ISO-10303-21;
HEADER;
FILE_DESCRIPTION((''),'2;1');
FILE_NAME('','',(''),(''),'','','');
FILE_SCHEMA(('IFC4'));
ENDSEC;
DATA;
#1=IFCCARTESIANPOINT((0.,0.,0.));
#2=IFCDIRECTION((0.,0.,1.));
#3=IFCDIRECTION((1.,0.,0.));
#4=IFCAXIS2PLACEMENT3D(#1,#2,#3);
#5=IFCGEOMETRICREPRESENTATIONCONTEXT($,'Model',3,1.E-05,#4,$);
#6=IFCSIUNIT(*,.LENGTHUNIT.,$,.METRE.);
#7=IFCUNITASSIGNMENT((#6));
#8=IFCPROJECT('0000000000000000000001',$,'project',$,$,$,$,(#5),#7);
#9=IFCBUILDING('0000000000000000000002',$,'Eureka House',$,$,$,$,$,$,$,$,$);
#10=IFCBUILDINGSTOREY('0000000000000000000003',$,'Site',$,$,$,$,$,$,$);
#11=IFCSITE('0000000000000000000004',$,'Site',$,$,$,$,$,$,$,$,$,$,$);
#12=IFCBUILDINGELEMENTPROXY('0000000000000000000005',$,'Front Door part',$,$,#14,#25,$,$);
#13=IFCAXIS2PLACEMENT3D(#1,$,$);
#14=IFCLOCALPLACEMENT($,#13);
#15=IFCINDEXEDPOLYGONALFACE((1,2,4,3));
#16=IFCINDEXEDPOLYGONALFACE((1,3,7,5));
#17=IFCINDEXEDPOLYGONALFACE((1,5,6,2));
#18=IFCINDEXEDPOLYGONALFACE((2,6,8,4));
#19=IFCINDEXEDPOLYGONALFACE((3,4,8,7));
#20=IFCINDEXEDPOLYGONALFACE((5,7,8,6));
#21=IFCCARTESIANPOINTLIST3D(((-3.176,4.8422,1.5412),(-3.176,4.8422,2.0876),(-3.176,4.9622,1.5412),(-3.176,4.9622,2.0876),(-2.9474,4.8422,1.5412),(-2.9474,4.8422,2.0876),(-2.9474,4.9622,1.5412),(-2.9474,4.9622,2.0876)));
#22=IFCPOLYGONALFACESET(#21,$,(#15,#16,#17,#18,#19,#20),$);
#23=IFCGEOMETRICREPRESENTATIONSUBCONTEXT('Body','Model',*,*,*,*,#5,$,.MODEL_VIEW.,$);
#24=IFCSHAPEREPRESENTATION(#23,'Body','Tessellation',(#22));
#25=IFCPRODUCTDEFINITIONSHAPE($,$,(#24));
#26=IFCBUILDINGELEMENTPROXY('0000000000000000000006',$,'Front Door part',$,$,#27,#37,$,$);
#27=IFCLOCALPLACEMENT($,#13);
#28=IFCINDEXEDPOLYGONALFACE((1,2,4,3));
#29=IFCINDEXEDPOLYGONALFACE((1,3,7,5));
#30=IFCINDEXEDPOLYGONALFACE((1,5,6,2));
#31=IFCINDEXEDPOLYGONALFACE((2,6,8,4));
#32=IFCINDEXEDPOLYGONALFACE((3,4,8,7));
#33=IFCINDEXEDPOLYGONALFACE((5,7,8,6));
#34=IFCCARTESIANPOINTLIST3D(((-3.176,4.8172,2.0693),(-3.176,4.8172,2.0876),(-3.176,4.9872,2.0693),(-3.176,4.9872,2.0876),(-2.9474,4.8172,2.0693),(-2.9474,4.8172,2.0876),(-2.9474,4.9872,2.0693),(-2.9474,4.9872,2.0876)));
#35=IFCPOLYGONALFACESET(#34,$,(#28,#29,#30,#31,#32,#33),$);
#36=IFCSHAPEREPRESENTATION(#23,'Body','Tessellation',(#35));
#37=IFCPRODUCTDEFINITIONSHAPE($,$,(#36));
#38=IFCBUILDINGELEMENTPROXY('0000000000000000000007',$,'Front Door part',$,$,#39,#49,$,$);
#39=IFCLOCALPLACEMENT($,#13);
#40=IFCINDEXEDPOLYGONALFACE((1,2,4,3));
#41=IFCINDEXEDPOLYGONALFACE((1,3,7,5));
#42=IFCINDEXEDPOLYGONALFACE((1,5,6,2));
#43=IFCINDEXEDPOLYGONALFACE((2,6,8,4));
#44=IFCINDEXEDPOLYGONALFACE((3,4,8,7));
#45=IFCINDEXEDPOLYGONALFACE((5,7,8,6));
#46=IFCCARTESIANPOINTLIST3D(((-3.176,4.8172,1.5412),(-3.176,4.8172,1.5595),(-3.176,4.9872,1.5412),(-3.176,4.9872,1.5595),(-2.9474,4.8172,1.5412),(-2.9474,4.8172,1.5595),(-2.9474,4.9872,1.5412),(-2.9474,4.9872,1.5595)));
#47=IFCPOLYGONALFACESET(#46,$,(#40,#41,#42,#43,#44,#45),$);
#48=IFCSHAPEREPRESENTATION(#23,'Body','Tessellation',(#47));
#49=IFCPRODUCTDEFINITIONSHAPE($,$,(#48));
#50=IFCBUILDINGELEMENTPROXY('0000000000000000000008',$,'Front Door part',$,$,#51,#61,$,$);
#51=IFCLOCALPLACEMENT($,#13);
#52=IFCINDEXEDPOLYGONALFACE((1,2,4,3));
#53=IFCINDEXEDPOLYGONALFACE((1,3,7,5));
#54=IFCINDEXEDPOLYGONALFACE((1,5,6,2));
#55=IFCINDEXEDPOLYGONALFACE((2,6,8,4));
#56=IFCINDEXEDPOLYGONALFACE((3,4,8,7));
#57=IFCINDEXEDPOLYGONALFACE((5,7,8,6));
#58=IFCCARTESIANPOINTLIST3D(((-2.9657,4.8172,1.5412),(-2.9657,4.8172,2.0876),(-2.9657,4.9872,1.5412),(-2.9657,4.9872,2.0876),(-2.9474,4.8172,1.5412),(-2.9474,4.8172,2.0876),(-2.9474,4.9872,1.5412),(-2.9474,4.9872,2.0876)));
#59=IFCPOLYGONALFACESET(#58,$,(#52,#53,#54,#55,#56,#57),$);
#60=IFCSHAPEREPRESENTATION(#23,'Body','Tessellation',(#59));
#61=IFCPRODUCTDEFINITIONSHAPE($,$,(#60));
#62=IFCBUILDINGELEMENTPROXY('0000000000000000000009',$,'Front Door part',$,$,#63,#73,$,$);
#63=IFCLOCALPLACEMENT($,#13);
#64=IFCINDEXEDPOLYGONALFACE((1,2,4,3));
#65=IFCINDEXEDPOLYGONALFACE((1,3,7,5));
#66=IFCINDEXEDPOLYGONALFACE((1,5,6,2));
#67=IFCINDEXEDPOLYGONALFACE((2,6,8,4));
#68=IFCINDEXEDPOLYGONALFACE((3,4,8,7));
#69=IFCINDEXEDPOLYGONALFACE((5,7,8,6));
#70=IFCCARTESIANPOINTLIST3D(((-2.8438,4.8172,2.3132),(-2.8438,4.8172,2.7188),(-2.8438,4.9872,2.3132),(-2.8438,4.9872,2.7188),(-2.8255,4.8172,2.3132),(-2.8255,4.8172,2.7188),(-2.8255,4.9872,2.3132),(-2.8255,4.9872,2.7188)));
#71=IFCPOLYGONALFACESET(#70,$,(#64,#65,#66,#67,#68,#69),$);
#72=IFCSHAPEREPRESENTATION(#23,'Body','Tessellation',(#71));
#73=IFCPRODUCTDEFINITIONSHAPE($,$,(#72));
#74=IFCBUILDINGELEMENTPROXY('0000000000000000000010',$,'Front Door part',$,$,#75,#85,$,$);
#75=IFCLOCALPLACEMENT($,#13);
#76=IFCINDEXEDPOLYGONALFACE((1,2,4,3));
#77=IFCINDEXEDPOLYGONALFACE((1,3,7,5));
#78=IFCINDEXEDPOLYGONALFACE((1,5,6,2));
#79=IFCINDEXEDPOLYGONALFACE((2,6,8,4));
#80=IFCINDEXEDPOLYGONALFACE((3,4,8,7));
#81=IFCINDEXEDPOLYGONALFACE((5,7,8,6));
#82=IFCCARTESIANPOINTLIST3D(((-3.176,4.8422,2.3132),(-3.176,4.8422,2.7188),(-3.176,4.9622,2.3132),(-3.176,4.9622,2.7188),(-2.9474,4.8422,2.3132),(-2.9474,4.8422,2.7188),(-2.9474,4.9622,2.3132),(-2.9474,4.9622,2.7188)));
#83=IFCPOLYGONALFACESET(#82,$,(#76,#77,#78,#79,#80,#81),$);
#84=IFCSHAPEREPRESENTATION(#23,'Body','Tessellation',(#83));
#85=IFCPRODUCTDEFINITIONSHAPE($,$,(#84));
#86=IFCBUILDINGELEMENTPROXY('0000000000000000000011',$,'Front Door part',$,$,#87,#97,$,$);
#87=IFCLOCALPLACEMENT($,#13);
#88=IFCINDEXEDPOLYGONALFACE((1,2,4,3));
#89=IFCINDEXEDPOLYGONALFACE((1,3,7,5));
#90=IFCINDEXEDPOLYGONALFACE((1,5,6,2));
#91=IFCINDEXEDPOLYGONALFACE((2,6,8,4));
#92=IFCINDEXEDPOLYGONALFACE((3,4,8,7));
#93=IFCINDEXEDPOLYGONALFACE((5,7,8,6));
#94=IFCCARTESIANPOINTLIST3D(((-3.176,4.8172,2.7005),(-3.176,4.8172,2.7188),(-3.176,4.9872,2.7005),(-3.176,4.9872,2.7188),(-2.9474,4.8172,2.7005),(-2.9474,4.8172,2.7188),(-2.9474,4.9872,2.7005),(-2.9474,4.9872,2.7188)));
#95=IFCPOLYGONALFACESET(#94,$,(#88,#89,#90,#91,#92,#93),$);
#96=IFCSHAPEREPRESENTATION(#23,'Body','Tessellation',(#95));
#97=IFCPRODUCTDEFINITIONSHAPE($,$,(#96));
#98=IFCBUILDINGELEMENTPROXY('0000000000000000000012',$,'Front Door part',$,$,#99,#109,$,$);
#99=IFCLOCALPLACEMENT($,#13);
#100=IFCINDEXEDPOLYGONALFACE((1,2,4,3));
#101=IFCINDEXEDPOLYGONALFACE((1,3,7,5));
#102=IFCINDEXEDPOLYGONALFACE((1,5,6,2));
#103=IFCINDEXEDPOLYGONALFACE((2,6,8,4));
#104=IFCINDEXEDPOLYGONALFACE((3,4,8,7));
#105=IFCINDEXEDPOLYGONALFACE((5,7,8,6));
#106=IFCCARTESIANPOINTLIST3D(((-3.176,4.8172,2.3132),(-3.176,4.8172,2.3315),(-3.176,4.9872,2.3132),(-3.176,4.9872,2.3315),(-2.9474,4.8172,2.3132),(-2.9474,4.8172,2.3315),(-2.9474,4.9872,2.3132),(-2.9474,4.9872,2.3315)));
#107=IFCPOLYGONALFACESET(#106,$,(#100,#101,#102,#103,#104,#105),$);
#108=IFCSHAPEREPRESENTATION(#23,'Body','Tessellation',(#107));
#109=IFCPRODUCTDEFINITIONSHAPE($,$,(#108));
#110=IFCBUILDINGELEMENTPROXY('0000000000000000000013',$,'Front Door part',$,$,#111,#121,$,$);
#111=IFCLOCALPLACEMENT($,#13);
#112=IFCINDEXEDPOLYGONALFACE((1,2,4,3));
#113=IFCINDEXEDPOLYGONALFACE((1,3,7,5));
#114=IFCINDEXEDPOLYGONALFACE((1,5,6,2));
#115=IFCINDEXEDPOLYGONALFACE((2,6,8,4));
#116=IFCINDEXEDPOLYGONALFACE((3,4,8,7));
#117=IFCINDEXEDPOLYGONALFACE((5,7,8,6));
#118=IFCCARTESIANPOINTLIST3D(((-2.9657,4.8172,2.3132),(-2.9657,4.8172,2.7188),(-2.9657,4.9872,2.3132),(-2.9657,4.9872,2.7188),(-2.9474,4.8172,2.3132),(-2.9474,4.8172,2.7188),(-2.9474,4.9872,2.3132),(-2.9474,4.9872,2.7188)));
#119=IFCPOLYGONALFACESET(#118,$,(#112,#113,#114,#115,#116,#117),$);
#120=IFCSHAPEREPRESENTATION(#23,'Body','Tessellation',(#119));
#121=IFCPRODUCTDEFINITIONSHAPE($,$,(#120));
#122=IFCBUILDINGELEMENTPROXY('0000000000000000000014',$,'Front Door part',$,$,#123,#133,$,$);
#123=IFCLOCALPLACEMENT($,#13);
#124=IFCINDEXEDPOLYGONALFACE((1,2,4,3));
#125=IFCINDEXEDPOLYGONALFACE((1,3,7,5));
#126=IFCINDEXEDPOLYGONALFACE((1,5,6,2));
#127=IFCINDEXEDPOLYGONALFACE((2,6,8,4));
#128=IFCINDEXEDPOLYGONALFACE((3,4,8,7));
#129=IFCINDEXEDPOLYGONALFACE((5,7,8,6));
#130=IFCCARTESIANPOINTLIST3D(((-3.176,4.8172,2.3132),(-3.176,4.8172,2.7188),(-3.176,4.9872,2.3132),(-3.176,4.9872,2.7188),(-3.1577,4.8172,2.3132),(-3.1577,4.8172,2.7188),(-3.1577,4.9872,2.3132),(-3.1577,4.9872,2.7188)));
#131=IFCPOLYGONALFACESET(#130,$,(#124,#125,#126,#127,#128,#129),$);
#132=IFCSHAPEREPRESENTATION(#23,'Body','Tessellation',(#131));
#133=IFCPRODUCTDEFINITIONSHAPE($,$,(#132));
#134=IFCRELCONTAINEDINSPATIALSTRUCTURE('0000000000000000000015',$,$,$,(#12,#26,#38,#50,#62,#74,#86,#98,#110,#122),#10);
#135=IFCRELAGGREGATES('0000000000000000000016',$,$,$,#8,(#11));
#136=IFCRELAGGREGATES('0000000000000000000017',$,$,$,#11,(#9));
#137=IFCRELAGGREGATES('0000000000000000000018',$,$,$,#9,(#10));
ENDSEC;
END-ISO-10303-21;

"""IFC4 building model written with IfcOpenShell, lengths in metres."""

from ifc_helpers import new_model, si_unit, frame, origin, origin_with_axes, origin_2d, place, context, subcontext, project, spatial, rectangle, extrude, element, save


model = new_model("IFC4")

# Units and contexts
model_context = context("Model", 3, precision=1e-05, world=origin_with_axes())
body_context = subcontext(model_context, "Body", "Model", "MODEL_VIEW")
ifc_project = project(units=[si_unit("LENGTHUNIT", "METRE")], contexts=[model_context])

# Site, building, storey
site = spatial("IfcSite", under=ifc_project, Name="Site")
building = spatial("IfcBuilding", under=site, Name="Eureka House")
storey = spatial("IfcBuildingStorey", under=building, Name="Site")

# Building element proxies
proxy_1_placement = place(None, frame((-3.0617, 4.9022, 1.5412), z_axis=(0.0, 0.0, 1.0), x_axis=(1.0, 0.0, 0.0)))
element("IfcBuildingElementProxy", 1, at=proxy_1_placement, inside=storey, Name="Front Door part", context=body_context, shape_type="SweptSolid", body=[
    extrude(rectangle(XDim=0.2286, YDim=0.12, at=origin_2d()), origin(), (0.0, 0.0, 1.0), 0.5464),
])
for number, where, z_axis, x_axis, name in (
    (2, (-3.0617, 4.9022, 2.0693), (0.0, 0.0, 1.0), (1.0, 0.0, 0.0), "Front Door part"),
    (3, (-3.0617, 4.9022, 1.5412), (0.0, 0.0, 1.0), (1.0, 0.0, 0.0), "Front Door part"),
):
    element("IfcBuildingElementProxy", number, at=place(None, frame(where, z_axis=z_axis, x_axis=x_axis)), inside=storey, Name=name, context=body_context, shape_type="SweptSolid", body=[
        extrude(rectangle(XDim=0.2286, YDim=0.17, at=origin_2d()), origin(), (0.0, 0.0, 1.0), 0.0183),
    ])
proxy_2_placement = place(None, frame((-2.9566, 4.9022, 1.5412), z_axis=(0.0, 0.0, 1.0), x_axis=(1.0, 0.0, 0.0)))
element("IfcBuildingElementProxy", 4, at=proxy_2_placement, inside=storey, Name="Front Door part", context=body_context, shape_type="SweptSolid", body=[
    extrude(rectangle(XDim=0.0183, YDim=0.17, at=origin_2d()), origin(), (0.0, 0.0, 1.0), 0.5464),
])
proxy_3_placement = place(None, frame((-2.8346, 4.9022, 2.3132), z_axis=(0.0, 0.0, 1.0), x_axis=(1.0, 0.0, 0.0)))
element("IfcBuildingElementProxy", 5, at=proxy_3_placement, inside=storey, Name="Front Door part", context=body_context, shape_type="SweptSolid", body=[
    extrude(rectangle(XDim=0.0183, YDim=0.17, at=origin_2d()), origin(), (0.0, 0.0, 1.0), 0.4056),
])
proxy_4_placement = place(None, frame((-3.0617, 4.9022, 2.3132), z_axis=(0.0, 0.0, 1.0), x_axis=(1.0, 0.0, 0.0)))
element("IfcBuildingElementProxy", 6, at=proxy_4_placement, inside=storey, Name="Front Door part", context=body_context, shape_type="SweptSolid", body=[
    extrude(rectangle(XDim=0.2286, YDim=0.12, at=origin_2d()), origin(), (0.0, 0.0, 1.0), 0.4056),
])
for number, where, z_axis, x_axis, name in (
    (7, (-3.0617, 4.9022, 2.7005), (0.0, 0.0, 1.0), (1.0, 0.0, 0.0), "Front Door part"),
    (8, (-3.0617, 4.9022, 2.3132), (0.0, 0.0, 1.0), (1.0, 0.0, 0.0), "Front Door part"),
):
    element("IfcBuildingElementProxy", number, at=place(None, frame(where, z_axis=z_axis, x_axis=x_axis)), inside=storey, Name=name, context=body_context, shape_type="SweptSolid", body=[
        extrude(rectangle(XDim=0.2286, YDim=0.17, at=origin_2d()), origin(), (0.0, 0.0, 1.0), 0.0183),
    ])
for number, where, z_axis, x_axis, name in (
    (9, (-2.9566, 4.9022, 2.3132), (0.0, 0.0, 1.0), (1.0, 0.0, 0.0), "Front Door part"),
    (10, (-3.1669, 4.9022, 2.3132), (0.0, 0.0, 1.0), (1.0, 0.0, 0.0), "Front Door part"),
):
    element("IfcBuildingElementProxy", number, at=place(None, frame(where, z_axis=z_axis, x_axis=x_axis)), inside=storey, Name=name, context=body_context, shape_type="SweptSolid", body=[
        extrude(rectangle(XDim=0.0183, YDim=0.17, at=origin_2d()), origin(), (0.0, 0.0, 1.0), 0.4056),
    ])

save(model, "model.ifc")
